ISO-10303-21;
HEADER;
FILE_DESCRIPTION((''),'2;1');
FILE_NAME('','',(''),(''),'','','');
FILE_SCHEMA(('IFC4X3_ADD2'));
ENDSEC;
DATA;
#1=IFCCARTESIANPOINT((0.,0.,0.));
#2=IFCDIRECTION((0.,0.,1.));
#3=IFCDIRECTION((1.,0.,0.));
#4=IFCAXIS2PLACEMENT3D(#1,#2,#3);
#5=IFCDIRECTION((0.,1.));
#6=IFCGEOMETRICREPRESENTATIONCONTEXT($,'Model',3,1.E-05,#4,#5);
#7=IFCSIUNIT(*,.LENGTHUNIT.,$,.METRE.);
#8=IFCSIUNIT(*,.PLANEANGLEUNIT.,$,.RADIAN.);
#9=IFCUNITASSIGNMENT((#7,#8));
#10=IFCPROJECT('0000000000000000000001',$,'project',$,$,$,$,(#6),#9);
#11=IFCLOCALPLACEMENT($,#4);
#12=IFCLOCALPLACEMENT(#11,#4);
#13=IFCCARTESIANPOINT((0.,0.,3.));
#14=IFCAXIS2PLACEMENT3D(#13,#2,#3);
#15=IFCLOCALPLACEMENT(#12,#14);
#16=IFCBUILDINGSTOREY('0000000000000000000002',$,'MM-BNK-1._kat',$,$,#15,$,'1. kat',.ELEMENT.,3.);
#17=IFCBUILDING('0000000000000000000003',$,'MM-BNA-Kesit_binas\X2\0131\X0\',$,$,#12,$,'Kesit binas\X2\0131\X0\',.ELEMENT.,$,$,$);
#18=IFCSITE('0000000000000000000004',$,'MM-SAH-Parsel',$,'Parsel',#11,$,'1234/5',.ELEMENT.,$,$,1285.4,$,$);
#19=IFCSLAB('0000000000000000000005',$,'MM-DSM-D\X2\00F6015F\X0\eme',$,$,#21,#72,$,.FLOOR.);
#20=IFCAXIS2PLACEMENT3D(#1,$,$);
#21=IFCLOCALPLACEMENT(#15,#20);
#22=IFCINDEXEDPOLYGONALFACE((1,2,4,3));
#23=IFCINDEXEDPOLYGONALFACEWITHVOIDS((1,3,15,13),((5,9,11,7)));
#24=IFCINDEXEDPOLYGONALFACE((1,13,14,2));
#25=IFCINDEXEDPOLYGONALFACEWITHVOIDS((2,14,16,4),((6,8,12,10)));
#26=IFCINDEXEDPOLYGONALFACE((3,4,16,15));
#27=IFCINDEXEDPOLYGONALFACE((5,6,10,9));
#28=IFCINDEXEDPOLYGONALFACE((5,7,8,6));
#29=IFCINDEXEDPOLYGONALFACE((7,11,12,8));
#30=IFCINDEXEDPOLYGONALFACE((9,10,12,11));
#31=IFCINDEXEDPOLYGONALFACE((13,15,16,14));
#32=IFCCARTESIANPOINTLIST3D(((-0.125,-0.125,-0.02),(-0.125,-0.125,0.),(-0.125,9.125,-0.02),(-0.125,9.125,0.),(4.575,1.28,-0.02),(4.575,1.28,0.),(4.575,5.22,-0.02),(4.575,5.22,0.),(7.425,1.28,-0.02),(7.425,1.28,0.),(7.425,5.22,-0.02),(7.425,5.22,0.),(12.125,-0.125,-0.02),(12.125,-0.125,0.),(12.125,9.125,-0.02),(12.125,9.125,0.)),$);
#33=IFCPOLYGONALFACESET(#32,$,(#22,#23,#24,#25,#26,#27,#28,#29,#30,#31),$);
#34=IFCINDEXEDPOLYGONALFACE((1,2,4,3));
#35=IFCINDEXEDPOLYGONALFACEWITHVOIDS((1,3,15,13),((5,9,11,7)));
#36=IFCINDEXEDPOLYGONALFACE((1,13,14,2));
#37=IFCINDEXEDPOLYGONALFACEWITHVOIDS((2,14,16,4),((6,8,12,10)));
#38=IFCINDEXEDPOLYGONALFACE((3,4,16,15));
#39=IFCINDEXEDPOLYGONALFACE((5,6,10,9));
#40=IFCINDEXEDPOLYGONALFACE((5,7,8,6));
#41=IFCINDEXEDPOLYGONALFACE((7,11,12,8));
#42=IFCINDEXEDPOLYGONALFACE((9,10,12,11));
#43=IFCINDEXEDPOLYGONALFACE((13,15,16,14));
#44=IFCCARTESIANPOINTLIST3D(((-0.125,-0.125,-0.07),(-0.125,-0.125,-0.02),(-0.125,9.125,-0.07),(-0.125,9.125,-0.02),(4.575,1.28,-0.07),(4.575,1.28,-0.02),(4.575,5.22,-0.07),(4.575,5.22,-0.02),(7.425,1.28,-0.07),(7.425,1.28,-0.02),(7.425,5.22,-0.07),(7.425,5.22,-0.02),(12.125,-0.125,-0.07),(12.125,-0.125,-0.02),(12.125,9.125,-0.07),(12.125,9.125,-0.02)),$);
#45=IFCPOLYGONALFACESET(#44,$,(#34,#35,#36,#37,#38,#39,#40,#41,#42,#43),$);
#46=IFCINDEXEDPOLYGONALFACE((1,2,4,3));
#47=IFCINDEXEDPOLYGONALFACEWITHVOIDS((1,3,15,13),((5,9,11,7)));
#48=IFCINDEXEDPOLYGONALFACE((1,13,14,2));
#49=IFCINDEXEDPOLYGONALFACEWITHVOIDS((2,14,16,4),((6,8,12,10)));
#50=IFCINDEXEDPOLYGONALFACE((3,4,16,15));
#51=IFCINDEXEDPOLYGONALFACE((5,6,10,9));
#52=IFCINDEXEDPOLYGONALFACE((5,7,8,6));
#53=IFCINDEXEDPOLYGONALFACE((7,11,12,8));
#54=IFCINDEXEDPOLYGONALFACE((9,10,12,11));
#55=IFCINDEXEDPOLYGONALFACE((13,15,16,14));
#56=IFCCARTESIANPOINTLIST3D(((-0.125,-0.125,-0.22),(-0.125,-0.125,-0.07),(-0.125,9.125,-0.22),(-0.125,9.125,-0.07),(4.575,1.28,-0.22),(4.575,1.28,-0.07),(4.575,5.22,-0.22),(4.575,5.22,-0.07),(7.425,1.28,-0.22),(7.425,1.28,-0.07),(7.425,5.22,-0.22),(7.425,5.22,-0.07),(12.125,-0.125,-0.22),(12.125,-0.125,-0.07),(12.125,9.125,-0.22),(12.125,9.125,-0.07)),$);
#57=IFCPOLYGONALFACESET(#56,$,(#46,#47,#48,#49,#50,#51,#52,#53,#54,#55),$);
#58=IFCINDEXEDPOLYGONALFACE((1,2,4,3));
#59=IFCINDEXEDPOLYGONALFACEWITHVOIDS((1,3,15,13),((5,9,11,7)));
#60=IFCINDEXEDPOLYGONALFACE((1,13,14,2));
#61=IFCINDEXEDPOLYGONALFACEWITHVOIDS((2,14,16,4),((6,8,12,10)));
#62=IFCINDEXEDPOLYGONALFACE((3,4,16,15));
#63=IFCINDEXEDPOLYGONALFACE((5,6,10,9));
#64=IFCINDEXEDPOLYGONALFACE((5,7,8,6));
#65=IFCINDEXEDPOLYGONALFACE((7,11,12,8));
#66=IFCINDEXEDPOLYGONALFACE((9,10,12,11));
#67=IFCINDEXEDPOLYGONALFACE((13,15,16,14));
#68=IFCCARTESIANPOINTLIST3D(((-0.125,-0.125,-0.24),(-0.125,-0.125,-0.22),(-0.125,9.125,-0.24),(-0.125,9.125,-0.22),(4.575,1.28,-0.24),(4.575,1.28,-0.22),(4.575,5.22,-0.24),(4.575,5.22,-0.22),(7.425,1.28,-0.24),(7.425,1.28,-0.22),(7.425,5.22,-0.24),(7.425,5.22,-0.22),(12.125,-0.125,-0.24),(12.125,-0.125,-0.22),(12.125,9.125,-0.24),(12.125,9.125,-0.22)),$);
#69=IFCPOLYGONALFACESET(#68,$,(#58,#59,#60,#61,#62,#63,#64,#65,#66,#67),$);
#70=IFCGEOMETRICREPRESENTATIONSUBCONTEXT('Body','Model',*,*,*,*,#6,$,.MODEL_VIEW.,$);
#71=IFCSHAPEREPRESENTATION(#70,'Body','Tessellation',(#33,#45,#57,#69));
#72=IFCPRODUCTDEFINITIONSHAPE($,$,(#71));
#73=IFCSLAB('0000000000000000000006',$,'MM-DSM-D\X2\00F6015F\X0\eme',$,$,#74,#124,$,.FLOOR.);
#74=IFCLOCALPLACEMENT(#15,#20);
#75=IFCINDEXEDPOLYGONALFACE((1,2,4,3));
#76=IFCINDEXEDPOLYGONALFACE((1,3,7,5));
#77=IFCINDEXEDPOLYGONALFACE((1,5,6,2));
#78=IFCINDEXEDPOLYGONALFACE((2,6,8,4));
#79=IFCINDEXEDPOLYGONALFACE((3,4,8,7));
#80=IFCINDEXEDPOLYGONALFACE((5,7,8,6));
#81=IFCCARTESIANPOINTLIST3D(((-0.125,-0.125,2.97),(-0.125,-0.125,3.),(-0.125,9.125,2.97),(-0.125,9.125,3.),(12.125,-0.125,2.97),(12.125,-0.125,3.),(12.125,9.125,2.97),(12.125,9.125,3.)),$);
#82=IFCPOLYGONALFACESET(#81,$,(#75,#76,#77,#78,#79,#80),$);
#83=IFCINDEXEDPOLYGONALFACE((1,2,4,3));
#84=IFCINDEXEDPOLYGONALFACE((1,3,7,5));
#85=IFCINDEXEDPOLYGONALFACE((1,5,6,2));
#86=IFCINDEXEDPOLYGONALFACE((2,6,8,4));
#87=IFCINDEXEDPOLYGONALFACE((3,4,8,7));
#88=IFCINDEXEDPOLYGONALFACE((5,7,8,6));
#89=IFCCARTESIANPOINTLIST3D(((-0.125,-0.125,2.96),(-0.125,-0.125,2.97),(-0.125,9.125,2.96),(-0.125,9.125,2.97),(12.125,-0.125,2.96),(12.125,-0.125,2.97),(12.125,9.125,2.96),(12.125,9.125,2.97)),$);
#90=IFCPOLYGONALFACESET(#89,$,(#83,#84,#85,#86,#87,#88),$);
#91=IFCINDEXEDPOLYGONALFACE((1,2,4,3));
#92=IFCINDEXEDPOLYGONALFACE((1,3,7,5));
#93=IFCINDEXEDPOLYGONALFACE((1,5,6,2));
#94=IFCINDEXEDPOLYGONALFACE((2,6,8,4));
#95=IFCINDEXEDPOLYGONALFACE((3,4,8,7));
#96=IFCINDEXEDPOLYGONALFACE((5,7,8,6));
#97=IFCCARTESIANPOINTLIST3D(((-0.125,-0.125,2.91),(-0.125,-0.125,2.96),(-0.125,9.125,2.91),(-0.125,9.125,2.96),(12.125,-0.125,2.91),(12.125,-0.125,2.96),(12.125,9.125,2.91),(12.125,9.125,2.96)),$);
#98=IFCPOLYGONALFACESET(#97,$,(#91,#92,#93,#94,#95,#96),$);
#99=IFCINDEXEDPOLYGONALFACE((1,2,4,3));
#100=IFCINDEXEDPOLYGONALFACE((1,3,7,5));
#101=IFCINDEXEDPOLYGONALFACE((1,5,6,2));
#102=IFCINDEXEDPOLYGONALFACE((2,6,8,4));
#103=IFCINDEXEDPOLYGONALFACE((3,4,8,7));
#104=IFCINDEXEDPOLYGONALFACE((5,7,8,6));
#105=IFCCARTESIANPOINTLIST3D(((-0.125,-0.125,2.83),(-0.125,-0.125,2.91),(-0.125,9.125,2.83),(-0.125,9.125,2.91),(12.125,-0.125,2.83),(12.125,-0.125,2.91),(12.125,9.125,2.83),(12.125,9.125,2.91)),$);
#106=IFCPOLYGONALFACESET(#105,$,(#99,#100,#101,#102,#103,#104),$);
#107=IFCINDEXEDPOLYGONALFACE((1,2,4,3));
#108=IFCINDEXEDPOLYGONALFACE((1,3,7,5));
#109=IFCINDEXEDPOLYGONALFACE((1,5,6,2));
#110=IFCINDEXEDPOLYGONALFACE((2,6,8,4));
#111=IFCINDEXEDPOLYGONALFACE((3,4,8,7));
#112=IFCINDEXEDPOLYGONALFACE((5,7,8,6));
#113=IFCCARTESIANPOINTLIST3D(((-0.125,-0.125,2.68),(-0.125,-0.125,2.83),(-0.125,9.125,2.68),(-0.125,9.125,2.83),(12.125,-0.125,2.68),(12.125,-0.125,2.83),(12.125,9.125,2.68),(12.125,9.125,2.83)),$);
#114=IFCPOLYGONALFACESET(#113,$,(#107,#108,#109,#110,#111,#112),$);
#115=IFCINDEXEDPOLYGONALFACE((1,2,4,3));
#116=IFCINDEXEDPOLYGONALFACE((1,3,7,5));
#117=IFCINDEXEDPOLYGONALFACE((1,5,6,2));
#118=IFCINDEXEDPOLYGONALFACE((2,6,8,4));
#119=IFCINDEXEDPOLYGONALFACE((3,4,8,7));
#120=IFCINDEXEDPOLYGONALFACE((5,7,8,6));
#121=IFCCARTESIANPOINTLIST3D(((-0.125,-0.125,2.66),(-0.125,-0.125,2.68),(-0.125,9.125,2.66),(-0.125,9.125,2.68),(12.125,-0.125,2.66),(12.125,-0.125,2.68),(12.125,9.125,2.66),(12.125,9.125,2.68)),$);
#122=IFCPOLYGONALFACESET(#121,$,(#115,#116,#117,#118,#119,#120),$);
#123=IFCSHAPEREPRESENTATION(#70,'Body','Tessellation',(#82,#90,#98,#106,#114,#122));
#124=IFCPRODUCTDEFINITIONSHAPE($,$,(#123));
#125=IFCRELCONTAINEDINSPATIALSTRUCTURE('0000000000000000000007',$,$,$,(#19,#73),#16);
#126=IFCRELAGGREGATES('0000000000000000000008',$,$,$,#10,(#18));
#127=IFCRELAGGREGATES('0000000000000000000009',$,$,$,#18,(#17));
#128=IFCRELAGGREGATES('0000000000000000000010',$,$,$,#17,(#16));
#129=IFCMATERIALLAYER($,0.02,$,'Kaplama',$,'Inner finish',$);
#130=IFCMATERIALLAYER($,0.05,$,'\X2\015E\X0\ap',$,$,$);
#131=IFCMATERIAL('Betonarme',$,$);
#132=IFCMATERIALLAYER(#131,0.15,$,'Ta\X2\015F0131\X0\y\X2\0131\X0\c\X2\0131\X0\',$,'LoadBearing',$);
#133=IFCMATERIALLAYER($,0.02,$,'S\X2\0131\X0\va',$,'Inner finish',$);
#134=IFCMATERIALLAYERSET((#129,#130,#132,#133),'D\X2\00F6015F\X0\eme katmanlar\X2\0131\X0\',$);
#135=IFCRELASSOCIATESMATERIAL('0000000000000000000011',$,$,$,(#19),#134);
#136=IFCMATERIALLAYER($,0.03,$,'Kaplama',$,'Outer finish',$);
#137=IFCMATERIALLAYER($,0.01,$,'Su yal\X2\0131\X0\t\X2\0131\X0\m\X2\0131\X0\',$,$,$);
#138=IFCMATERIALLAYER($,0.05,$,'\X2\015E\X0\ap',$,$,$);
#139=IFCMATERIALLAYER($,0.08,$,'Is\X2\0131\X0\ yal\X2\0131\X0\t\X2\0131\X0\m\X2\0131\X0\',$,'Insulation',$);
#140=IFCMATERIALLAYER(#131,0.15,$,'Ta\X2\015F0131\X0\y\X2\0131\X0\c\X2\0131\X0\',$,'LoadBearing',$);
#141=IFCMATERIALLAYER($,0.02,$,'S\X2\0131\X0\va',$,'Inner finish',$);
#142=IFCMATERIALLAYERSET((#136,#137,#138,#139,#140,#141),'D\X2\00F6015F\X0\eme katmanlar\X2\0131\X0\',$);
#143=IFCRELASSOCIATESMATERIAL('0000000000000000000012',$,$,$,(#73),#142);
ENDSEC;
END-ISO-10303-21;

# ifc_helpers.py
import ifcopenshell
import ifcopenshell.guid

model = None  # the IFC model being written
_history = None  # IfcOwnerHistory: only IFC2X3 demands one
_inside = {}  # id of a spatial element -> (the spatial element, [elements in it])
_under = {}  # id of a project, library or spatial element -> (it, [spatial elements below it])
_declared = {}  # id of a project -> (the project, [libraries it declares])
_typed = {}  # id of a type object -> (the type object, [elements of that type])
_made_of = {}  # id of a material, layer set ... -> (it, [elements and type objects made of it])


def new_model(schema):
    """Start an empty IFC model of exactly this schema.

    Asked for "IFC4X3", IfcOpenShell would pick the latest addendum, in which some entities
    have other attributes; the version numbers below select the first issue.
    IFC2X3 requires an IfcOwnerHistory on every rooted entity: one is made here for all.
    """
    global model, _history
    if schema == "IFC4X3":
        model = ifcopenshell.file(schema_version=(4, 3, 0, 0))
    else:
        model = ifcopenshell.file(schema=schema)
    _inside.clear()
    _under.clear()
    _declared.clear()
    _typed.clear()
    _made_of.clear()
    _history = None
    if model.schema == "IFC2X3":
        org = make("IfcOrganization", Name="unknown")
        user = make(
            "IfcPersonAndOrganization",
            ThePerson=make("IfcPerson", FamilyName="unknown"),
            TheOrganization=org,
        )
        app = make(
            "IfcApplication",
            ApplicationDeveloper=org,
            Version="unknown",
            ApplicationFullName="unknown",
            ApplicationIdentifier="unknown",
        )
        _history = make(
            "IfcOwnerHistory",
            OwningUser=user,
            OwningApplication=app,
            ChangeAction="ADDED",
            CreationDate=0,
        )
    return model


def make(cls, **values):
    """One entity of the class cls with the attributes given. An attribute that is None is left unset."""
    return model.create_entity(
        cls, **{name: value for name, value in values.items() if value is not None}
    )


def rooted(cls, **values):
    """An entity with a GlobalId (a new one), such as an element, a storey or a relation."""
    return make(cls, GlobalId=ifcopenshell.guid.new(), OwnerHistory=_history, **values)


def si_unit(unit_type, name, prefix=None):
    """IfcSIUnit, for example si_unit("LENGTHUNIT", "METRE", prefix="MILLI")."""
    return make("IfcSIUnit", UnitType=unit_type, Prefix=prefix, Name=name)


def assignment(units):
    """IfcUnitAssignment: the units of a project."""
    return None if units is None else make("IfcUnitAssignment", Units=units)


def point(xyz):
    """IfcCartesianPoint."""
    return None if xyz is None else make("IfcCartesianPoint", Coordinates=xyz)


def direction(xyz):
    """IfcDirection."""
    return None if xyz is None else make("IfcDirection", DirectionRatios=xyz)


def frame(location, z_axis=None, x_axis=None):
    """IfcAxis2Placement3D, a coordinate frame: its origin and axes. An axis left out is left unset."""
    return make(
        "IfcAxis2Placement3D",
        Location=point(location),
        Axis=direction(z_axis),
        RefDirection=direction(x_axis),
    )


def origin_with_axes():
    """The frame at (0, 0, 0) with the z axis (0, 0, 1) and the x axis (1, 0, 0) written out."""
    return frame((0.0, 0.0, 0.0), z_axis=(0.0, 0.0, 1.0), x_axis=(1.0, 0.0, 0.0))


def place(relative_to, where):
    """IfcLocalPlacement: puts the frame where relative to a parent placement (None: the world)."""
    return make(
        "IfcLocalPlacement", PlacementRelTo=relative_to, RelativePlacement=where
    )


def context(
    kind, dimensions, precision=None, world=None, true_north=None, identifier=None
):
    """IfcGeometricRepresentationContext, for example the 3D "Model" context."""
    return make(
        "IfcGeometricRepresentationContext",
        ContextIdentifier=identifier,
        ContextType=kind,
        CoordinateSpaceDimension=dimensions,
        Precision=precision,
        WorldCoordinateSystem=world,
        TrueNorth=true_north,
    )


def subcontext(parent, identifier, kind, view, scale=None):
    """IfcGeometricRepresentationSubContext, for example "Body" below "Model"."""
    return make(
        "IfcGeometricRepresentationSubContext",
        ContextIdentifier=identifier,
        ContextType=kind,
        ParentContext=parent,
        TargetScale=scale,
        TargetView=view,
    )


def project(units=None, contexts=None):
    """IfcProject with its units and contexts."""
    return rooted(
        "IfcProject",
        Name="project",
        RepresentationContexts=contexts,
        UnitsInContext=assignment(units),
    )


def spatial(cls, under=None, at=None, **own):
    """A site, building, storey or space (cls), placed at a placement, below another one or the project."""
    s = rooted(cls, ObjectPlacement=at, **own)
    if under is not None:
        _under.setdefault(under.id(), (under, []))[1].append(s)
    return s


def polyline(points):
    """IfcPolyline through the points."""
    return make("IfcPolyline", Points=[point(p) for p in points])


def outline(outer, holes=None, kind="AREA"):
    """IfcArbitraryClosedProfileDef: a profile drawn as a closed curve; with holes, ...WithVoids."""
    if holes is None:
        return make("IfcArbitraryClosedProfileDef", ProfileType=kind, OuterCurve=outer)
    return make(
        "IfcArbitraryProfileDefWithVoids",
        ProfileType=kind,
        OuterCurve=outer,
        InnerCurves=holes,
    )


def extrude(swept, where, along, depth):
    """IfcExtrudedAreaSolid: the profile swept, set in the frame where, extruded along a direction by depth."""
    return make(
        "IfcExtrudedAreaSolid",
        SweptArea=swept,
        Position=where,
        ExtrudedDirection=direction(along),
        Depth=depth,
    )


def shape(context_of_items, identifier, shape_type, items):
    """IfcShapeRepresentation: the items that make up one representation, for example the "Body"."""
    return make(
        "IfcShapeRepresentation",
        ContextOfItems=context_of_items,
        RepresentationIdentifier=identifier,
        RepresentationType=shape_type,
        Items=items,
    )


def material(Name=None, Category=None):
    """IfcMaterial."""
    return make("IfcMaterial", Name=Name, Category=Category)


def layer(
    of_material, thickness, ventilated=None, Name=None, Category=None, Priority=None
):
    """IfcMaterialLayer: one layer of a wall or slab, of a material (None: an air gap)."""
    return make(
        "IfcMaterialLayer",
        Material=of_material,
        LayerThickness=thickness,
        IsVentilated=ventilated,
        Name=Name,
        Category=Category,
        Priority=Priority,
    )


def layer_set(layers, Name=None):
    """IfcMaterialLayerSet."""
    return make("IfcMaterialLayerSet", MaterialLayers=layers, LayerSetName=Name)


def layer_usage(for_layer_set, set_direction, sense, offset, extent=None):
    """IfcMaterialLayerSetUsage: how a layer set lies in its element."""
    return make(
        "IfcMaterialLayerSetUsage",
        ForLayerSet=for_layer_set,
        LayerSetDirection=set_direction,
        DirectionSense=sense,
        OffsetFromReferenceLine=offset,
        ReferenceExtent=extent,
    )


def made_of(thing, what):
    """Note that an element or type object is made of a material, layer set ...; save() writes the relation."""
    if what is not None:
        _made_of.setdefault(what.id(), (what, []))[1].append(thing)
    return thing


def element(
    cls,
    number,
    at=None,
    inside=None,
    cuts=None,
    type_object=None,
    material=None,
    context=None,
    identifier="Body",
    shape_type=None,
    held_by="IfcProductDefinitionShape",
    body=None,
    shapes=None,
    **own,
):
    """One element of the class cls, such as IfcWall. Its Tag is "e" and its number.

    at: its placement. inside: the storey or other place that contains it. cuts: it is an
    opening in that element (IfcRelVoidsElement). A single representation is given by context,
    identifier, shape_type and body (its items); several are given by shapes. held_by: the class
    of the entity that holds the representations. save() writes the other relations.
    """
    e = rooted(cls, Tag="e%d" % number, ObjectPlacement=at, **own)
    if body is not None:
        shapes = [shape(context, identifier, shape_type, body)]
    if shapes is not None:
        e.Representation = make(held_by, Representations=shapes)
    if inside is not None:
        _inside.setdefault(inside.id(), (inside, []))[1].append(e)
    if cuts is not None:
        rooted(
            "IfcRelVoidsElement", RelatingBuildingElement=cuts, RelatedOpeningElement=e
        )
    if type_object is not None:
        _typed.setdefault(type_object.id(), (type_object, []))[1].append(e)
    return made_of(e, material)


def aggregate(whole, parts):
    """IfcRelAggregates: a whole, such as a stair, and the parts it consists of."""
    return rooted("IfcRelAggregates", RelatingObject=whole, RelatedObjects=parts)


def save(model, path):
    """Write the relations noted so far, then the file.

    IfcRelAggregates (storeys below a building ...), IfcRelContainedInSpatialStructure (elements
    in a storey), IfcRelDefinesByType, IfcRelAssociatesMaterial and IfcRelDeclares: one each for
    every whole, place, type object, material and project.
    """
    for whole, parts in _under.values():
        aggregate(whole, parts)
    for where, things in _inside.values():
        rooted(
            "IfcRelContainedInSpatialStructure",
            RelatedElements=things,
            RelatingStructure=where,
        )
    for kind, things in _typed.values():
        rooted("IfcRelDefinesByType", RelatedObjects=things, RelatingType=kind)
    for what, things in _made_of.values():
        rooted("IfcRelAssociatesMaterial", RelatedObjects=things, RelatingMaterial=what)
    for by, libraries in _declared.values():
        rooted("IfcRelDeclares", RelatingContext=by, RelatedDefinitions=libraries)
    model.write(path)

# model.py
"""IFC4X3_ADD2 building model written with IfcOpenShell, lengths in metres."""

from ifc_helpers import new_model, si_unit, direction, frame, origin_with_axes, place, context, subcontext, project, spatial, polyline, outline, extrude, material, layer, layer_set, layer_usage, element, save


model = new_model("IFC4X3_ADD2")

# Units and contexts
model_context = context("Model", 3, precision=1e-05, world=origin_with_axes(), true_north=direction((0.0, 1.0)))
body_context = subcontext(model_context, "Body", "Model", "MODEL_VIEW")
ifc_project = project(units=[si_unit("LENGTHUNIT", "METRE"), si_unit("PLANEANGLEUNIT", "RADIAN")], contexts=[model_context])

# Site, building, storey
site_placement = place(None, origin_with_axes())
site = spatial("IfcSite", under=ifc_project, at=site_placement, Name="MM-SAH-Parsel", ObjectType="Parsel", LongName="1234/5", CompositionType="ELEMENT", RefElevation=1285.4)
building_placement = place(site_placement, origin_with_axes())
building = spatial("IfcBuilding", under=site, at=building_placement, Name="MM-BNA-Kesit_binası", LongName="Kesit binası", CompositionType="ELEMENT")
storey_placement = place(building_placement, frame((0.0, 0.0, 3.0), z_axis=(0.0, 0.0, 1.0), x_axis=(1.0, 0.0, 0.0)))
storey = spatial("IfcBuildingStorey", under=building, at=storey_placement, Name="MM-BNK-1._kat", LongName="1. kat", CompositionType="ELEMENT", Elevation=3.0)

# Shared definitions
ifc_material_1 = material(Name="Betonarme")

# Slab, opening
ifc_layer_1 = layer(None, 0.02, Name="Kaplama", Category="Inner finish")
ifc_layer_2 = layer(None, 0.05, Name="Şap")
ifc_layer_3 = layer(ifc_material_1, 0.15, Name="Taşıyıcı", Category="LoadBearing")
ifc_layer_4 = layer(None, 0.02, Name="Sıva", Category="Inner finish")
ifc_layer_set_1 = layer_set([ifc_layer_1, ifc_layer_2, ifc_layer_3, ifc_layer_4], Name="Döşeme katmanları")
ifc_layer_usage_1 = layer_usage(ifc_layer_set_1, "AXIS3", "NEGATIVE", 0.0)
slab_1_placement = place(storey_placement, origin_with_axes())
slab_1 = element("IfcSlab", 1, at=slab_1_placement, inside=storey, material=ifc_layer_usage_1, Name="MM-DSM-Döşeme", PredefinedType="FLOOR", context=body_context, shape_type="SweptSolid", body=[
    extrude(outline(polyline([(-0.125, -0.125), (12.125, -0.125), (12.125, 9.125), (-0.125, 9.125), (-0.125, -0.125)])), frame((0.0, 0.0, -0.02)), (0.0, 0.0, 1.0), 0.02),
    extrude(outline(polyline([(-0.125, -0.125), (12.125, -0.125), (12.125, 9.125), (-0.125, 9.125), (-0.125, -0.125)])), frame((0.0, 0.0, -0.07)), (0.0, 0.0, 1.0), 0.05),
    extrude(outline(polyline([(-0.125, -0.125), (12.125, -0.125), (12.125, 9.125), (-0.125, 9.125), (-0.125, -0.125)])), frame((0.0, 0.0, -0.22)), (0.0, 0.0, 1.0), 0.15),
    extrude(outline(polyline([(-0.125, -0.125), (12.125, -0.125), (12.125, 9.125), (-0.125, 9.125), (-0.125, -0.125)])), frame((0.0, 0.0, -0.24)), (0.0, 0.0, 1.0), 0.02),
])
opening_1_placement = place(storey_placement, origin_with_axes())
element("IfcOpeningElement", 2, at=opening_1_placement, cuts=slab_1, PredefinedType="OPENING", context=body_context, shape_type="SweptSolid", body=[
    extrude(outline(polyline([(4.575, 1.28), (4.575, 5.22), (7.425, 5.22), (7.425, 1.28), (4.575, 1.28)])), frame((0.0, 0.0, -0.24)), (0.0, 0.0, 1.0), 0.24),
])

# Slab
ifc_layer_5 = layer(None, 0.03, Name="Kaplama", Category="Outer finish")
ifc_layer_6 = layer(None, 0.01, Name="Su yalıtımı")
ifc_layer_7 = layer(None, 0.05, Name="Şap")
ifc_layer_8 = layer(None, 0.08, Name="Isı yalıtımı", Category="Insulation")
ifc_layer_9 = layer(ifc_material_1, 0.15, Name="Taşıyıcı", Category="LoadBearing")
ifc_layer_10 = layer(None, 0.02, Name="Sıva", Category="Inner finish")
ifc_layer_set_2 = layer_set([ifc_layer_5, ifc_layer_6, ifc_layer_7, ifc_layer_8, ifc_layer_9, ifc_layer_10], Name="Döşeme katmanları")
ifc_layer_usage_2 = layer_usage(ifc_layer_set_2, "AXIS3", "NEGATIVE", 3.0)
slab_2_placement = place(storey_placement, origin_with_axes())
element("IfcSlab", 3, at=slab_2_placement, inside=storey, material=ifc_layer_usage_2, Name="MM-DSM-Döşeme", PredefinedType="FLOOR", context=body_context, shape_type="SweptSolid", body=[
    extrude(outline(polyline([(-0.125, -0.125), (12.125, -0.125), (12.125, 9.125), (-0.125, 9.125), (-0.125, -0.125)])), frame((0.0, 0.0, 2.97)), (0.0, 0.0, 1.0), 0.03),
    extrude(outline(polyline([(-0.125, -0.125), (12.125, -0.125), (12.125, 9.125), (-0.125, 9.125), (-0.125, -0.125)])), frame((0.0, 0.0, 2.96)), (0.0, 0.0, 1.0), 0.01),
    extrude(outline(polyline([(-0.125, -0.125), (12.125, -0.125), (12.125, 9.125), (-0.125, 9.125), (-0.125, -0.125)])), frame((0.0, 0.0, 2.91)), (0.0, 0.0, 1.0), 0.05),
    extrude(outline(polyline([(-0.125, -0.125), (12.125, -0.125), (12.125, 9.125), (-0.125, 9.125), (-0.125, -0.125)])), frame((0.0, 0.0, 2.83)), (0.0, 0.0, 1.0), 0.08),
    extrude(outline(polyline([(-0.125, -0.125), (12.125, -0.125), (12.125, 9.125), (-0.125, 9.125), (-0.125, -0.125)])), frame((0.0, 0.0, 2.68)), (0.0, 0.0, 1.0), 0.15),
    extrude(outline(polyline([(-0.125, -0.125), (12.125, -0.125), (12.125, 9.125), (-0.125, 9.125), (-0.125, -0.125)])), frame((0.0, 0.0, 2.66)), (0.0, 0.0, 1.0), 0.02),
])

save(model, "model.ifc")
